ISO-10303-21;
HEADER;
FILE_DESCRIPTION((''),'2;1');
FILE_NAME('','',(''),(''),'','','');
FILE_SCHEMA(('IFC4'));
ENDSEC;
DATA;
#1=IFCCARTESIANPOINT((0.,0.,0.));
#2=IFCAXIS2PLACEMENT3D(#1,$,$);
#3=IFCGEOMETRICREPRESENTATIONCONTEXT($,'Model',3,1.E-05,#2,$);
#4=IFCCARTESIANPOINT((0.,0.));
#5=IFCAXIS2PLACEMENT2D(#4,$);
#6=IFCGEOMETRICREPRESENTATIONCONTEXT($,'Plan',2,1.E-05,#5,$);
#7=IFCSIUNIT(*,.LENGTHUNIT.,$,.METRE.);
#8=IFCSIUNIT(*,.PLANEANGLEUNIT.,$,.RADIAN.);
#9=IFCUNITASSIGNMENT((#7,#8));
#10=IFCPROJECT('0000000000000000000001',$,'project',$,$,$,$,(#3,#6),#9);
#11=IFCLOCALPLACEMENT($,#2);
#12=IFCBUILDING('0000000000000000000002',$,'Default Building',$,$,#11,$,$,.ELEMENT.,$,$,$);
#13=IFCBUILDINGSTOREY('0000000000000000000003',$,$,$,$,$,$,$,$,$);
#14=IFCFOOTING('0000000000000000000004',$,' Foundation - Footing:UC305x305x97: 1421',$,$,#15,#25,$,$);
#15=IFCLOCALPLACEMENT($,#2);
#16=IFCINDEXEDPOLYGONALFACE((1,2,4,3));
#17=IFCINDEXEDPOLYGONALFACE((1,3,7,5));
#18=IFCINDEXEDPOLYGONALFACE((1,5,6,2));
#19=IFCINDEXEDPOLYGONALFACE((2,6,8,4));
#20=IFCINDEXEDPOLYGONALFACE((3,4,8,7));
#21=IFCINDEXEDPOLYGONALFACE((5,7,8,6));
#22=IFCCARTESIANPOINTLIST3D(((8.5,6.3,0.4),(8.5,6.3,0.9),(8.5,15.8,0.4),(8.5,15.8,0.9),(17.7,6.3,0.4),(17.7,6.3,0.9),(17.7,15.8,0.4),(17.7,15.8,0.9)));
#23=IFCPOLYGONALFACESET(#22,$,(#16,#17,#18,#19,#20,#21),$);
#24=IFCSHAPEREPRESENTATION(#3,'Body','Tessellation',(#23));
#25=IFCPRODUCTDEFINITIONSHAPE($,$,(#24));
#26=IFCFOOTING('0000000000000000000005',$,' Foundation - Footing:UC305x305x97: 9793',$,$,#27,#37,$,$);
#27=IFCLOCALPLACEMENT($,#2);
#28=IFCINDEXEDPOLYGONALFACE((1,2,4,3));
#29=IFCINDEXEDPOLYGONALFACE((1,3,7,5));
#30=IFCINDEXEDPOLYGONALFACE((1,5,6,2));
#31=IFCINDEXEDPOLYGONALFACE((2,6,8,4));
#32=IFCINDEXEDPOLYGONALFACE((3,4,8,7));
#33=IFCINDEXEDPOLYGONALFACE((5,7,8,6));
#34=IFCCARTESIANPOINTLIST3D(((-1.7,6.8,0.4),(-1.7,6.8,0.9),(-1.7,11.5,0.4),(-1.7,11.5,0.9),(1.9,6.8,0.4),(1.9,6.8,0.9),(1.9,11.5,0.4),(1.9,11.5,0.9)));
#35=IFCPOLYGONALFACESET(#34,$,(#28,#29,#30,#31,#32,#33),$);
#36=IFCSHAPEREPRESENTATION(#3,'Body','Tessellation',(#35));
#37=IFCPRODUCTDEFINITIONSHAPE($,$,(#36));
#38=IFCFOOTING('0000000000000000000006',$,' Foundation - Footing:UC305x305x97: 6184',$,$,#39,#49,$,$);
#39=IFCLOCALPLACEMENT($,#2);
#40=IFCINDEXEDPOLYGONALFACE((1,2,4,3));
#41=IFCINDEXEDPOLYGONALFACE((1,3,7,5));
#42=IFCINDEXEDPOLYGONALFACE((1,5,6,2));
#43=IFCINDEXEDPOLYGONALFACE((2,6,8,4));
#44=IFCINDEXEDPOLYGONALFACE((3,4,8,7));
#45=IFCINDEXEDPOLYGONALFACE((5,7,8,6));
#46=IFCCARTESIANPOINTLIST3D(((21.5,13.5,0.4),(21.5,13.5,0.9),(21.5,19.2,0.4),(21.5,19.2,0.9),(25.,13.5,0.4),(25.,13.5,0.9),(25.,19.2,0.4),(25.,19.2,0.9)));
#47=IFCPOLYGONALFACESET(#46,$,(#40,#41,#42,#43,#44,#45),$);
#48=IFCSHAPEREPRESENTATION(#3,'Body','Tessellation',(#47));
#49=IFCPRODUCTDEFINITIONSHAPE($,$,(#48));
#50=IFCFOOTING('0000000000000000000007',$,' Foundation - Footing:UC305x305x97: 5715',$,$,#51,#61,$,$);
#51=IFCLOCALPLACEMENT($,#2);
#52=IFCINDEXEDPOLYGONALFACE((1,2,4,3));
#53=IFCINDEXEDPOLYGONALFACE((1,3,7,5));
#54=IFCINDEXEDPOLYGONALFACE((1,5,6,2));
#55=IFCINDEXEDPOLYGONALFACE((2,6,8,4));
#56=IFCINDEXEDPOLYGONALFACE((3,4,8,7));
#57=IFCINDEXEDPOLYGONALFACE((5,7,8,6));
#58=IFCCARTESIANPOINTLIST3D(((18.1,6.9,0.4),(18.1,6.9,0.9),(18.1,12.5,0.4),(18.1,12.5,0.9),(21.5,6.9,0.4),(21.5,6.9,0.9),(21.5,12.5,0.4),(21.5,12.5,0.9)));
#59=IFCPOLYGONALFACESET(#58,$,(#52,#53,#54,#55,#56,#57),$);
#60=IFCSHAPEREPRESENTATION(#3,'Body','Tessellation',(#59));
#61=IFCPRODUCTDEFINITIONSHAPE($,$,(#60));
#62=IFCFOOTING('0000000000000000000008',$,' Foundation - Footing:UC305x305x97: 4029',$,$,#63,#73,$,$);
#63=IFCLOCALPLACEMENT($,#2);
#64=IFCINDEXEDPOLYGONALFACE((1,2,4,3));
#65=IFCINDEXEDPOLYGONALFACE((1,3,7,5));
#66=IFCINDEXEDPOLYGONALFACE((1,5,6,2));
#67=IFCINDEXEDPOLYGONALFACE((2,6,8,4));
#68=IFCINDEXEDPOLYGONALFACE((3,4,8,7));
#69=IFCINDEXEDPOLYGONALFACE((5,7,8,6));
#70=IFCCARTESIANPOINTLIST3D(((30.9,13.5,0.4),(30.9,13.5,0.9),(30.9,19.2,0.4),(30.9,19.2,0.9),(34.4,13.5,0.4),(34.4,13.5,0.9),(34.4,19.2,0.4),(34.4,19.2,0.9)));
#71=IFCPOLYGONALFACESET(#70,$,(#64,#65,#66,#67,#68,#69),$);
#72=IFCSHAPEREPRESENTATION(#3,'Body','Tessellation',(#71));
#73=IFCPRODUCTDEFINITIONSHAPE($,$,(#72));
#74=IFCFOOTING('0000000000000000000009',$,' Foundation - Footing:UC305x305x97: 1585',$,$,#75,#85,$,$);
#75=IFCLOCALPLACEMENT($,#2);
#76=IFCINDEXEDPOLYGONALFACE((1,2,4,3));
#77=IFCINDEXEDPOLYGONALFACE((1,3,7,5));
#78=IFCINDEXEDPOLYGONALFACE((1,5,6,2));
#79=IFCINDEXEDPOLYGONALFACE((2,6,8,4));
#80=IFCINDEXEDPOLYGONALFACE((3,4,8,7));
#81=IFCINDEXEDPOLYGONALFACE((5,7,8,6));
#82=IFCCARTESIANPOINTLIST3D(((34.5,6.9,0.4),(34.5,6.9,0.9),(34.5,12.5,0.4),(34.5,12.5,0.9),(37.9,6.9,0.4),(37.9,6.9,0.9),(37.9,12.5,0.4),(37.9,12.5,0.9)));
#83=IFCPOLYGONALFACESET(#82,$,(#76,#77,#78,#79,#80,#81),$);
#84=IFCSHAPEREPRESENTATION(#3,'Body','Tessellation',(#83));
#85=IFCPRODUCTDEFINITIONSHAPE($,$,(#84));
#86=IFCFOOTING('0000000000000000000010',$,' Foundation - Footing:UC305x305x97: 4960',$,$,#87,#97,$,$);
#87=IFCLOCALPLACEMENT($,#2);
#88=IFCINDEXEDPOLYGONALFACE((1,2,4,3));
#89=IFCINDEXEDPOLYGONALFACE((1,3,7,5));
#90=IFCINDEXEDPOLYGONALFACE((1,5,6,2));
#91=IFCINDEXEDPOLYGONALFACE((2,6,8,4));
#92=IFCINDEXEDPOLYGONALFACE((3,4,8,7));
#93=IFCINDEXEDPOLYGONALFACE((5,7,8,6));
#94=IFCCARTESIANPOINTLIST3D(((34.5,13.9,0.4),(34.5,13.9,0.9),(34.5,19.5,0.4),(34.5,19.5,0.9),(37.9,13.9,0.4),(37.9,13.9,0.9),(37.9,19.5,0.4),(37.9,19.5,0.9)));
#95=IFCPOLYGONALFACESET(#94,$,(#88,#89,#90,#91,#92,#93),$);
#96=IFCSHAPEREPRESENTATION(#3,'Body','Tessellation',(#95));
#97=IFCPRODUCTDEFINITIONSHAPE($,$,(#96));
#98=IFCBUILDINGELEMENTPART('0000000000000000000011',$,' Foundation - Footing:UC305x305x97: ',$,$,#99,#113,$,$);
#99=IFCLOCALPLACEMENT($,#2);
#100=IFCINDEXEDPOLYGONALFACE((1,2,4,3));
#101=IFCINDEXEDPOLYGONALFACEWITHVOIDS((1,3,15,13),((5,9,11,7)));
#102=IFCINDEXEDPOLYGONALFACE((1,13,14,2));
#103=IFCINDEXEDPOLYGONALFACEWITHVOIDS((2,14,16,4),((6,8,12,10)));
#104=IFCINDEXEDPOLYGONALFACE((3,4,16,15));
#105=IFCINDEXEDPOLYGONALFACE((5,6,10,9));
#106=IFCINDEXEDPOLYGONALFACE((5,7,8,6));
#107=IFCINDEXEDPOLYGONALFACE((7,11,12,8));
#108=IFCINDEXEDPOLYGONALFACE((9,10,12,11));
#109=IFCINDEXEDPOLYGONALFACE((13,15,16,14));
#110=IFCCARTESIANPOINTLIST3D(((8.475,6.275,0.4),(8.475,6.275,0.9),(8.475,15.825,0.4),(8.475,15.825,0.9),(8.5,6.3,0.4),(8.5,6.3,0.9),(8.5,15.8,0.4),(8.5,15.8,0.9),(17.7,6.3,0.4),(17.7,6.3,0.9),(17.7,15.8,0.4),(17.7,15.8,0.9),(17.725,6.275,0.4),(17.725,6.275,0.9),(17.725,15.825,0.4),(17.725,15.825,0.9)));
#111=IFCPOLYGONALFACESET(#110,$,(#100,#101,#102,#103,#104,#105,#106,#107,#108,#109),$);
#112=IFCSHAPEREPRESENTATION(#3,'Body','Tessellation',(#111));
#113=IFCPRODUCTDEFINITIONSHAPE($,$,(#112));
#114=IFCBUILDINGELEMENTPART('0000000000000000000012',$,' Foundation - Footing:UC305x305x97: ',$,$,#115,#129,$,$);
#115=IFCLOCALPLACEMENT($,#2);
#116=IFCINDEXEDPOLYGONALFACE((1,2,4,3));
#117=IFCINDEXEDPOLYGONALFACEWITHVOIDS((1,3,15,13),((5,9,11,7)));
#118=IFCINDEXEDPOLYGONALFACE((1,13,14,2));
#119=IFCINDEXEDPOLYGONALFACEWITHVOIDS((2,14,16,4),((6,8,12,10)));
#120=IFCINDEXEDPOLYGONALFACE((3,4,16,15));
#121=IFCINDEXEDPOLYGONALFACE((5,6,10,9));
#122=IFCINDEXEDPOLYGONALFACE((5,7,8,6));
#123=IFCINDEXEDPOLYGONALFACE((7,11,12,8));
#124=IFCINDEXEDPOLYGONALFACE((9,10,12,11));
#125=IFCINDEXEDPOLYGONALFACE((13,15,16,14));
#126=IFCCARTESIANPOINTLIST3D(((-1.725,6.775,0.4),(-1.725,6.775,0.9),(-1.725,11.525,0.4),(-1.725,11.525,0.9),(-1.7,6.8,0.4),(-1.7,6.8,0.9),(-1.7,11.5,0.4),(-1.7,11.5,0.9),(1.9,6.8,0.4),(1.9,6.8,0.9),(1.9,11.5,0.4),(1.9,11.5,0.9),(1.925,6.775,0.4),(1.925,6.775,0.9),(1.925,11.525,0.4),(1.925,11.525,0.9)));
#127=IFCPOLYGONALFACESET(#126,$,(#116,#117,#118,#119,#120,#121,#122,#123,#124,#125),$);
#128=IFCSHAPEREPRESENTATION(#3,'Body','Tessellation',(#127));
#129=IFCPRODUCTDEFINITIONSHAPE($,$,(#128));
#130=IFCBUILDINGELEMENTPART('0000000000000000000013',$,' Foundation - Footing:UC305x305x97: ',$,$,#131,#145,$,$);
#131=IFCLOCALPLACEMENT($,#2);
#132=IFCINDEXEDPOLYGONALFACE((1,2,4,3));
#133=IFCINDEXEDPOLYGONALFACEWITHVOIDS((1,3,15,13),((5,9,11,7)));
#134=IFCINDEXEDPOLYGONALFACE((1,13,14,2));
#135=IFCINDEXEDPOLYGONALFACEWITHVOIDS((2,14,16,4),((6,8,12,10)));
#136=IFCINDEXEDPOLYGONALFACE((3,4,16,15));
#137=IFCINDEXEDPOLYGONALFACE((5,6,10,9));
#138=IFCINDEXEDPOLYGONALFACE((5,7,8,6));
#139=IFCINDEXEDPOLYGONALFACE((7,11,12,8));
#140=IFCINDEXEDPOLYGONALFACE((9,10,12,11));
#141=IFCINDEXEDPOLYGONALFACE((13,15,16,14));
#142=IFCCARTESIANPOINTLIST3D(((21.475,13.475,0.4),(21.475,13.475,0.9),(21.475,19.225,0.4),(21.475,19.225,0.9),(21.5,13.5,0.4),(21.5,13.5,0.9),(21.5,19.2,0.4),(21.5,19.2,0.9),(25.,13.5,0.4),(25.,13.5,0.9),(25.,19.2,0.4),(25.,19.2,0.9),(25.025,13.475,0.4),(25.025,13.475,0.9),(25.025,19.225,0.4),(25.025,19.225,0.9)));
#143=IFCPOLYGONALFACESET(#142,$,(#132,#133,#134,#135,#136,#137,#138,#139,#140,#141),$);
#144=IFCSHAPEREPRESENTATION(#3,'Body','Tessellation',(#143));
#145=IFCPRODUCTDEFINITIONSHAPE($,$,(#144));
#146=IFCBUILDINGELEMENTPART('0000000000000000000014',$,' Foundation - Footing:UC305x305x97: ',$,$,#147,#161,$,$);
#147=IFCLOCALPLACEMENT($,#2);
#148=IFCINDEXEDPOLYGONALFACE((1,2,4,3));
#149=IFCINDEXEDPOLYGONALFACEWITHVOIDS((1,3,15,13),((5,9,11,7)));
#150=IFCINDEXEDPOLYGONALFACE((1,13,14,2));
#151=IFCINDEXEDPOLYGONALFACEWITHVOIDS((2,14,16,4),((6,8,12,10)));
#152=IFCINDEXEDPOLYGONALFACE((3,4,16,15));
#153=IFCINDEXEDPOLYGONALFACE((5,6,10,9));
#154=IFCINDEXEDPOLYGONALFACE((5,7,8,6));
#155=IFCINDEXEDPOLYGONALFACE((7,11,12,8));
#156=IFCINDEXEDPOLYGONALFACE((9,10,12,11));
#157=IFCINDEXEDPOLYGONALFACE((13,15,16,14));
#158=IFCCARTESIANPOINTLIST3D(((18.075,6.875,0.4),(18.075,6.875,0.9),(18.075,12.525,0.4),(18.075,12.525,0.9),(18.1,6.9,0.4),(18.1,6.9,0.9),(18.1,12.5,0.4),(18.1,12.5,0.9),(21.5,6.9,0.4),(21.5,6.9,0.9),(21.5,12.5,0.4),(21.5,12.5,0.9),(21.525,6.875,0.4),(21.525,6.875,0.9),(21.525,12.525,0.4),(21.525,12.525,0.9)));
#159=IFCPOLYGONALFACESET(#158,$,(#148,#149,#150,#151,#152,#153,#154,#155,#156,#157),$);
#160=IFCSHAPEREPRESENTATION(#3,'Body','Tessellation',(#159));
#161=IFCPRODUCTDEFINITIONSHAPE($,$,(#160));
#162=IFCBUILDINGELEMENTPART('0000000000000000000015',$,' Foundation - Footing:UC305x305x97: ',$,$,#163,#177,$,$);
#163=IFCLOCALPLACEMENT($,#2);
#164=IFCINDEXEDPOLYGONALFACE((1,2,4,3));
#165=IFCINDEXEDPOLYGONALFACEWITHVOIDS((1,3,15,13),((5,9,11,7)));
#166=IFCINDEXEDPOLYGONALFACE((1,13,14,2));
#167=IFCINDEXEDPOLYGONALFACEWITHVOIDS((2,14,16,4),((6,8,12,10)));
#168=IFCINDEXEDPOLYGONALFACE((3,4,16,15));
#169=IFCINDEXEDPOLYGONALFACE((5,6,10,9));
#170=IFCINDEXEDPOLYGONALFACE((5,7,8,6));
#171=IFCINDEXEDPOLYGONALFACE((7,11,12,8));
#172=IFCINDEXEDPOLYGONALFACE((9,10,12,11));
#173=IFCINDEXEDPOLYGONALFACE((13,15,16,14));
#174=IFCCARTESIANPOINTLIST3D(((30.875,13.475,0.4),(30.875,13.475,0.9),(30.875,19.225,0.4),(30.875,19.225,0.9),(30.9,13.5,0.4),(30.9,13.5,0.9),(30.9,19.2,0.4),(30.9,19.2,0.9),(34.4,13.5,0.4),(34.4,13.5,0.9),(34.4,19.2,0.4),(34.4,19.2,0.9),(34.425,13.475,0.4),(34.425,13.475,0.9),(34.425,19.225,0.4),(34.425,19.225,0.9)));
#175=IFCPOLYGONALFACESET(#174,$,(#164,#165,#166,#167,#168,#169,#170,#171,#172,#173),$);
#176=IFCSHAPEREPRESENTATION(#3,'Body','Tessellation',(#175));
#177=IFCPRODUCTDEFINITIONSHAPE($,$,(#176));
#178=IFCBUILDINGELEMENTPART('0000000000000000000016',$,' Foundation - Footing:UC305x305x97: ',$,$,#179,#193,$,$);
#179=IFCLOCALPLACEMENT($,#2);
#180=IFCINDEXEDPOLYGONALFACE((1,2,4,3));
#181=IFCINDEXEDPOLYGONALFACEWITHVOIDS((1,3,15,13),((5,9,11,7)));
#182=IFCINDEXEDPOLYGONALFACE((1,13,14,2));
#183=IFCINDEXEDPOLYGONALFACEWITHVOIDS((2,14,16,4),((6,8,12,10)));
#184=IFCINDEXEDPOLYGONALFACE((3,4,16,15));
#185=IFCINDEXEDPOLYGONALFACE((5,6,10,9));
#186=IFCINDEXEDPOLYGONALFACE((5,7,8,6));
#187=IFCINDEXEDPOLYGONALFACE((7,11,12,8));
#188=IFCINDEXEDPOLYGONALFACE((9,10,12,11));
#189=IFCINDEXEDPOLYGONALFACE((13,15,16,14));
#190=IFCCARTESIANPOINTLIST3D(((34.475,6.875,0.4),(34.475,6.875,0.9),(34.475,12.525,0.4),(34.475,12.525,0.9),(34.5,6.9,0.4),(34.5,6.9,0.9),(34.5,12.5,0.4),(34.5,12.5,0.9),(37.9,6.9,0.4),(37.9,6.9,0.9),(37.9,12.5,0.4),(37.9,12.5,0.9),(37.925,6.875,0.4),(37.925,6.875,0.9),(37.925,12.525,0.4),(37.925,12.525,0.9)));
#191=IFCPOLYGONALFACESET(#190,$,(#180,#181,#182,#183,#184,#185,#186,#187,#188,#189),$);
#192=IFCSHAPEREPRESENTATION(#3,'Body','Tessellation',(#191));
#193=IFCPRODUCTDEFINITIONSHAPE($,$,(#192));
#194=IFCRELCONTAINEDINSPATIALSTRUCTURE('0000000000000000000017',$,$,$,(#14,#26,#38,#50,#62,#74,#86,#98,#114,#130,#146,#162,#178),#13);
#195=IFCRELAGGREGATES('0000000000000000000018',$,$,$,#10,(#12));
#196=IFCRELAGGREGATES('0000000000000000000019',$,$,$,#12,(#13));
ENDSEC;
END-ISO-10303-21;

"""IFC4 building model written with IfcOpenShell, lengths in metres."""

from ifc_helpers import new_model, si_unit, origin, origin_2d, place, context, project, spatial, polyline, outline, extrude, element, save


model = new_model("IFC4")

# Units and contexts
model_context = context("Model", 3, precision=1e-05, world=origin())
plan_context = context("Plan", 2, precision=1e-05, world=origin_2d())
ifc_project = project(units=[si_unit("LENGTHUNIT", "METRE"), si_unit("PLANEANGLEUNIT", "RADIAN")], contexts=[model_context, plan_context])

# Building, storey
building_placement = place(None, origin())
building = spatial("IfcBuilding", under=ifc_project, at=building_placement, Name="Default Building", CompositionType="ELEMENT")
storey = spatial("IfcBuildingStorey", under=building)

# Footings
element("IfcFooting", 1, inside=storey, Name=" Foundation - Footing:UC305x305x97: 1421", context=model_context, shape_type="SweptSolid", body=[
    extrude(outline(polyline([(8.5, 15.8, 0.4), (17.7, 15.8, 0.4), (17.7, 6.3, 0.4), (8.5, 6.3, 0.4), (8.5, 15.8, 0.4)])), None, (0.0, 0.0, 1.0), 0.5),
])
element("IfcFooting", 2, inside=storey, Name=" Foundation - Footing:UC305x305x97: 9793", context=model_context, shape_type="SweptSolid", body=[
    extrude(outline(polyline([(1.9, 11.5, 0.4), (-1.7, 11.5, 0.4), (-1.7, 6.8, 0.4), (1.9, 6.8, 0.4), (1.9, 11.5, 0.4)])), None, (0.0, 0.0, 1.0), 0.5),
])
element("IfcFooting", 3, inside=storey, Name=" Foundation - Footing:UC305x305x97: 6184", context=model_context, shape_type="SweptSolid", body=[
    extrude(outline(polyline([(25.0, 19.2, 0.4), (21.5, 19.2, 0.4), (21.5, 13.5, 0.4), (25.0, 13.5, 0.4), (25.0, 19.2, 0.4)])), None, (0.0, 0.0, 1.0), 0.5),
])
element("IfcFooting", 4, inside=storey, Name=" Foundation - Footing:UC305x305x97: 5715", context=model_context, shape_type="SweptSolid", body=[
    extrude(outline(polyline([(21.5, 12.5, 0.4), (18.1, 12.5, 0.4), (18.1, 6.9, 0.4), (21.5, 6.9, 0.4), (21.5, 12.5, 0.4)])), None, (0.0, 0.0, 1.0), 0.5),
])
element("IfcFooting", 5, inside=storey, Name=" Foundation - Footing:UC305x305x97: 4029", context=model_context, shape_type="SweptSolid", body=[
    extrude(outline(polyline([(34.4, 19.2, 0.4), (30.9, 19.2, 0.4), (30.9, 13.5, 0.4), (34.4, 13.5, 0.4), (34.4, 19.2, 0.4)])), None, (0.0, 0.0, 1.0), 0.5),
])
element("IfcFooting", 6, inside=storey, Name=" Foundation - Footing:UC305x305x97: 1585", context=model_context, shape_type="SweptSolid", body=[
    extrude(outline(polyline([(37.9, 12.5, 0.4), (34.5, 12.5, 0.4), (34.5, 6.9, 0.4), (37.9, 6.9, 0.4), (37.9, 12.5, 0.4)])), None, (0.0, 0.0, 1.0), 0.5),
])
element("IfcFooting", 7, inside=storey, Name=" Foundation - Footing:UC305x305x97: 4960", context=model_context, shape_type="SweptSolid", body=[
    extrude(outline(polyline([(37.9, 19.5, 0.4), (34.5, 19.5, 0.4), (34.5, 13.9, 0.4), (37.9, 13.9, 0.4), (37.9, 19.5, 0.4)])), None, (0.0, 0.0, 1.0), 0.5),
])

# Building element parts, openings
building_element_part_1 = element("IfcBuildingElementPart", 8, inside=storey, Name=" Foundation - Footing:UC305x305x97: ", context=model_context, shape_type="SweptSolid", body=[
    extrude(outline(polyline([(8.475, 15.825, 0.4), (17.725, 15.825, 0.4), (17.725, 6.275, 0.4), (8.475, 6.275, 0.4), (8.475, 15.825, 0.4)])), None, (0.0, 0.0, 1.0), 0.5),
])
element("IfcOpeningElement", 9, inside=storey, cuts=building_element_part_1, context=model_context, shape_type="SweptSolid", body=[
    extrude(outline(polyline([(8.5, 15.8, 0.4), (17.7, 15.8, 0.4), (17.7, 6.3, 0.4), (8.5, 6.3, 0.4), (8.5, 15.8, 0.4)])), None, (0.0, 0.0, 1.0), 0.5),
])
building_element_part_2 = element("IfcBuildingElementPart", 10, inside=storey, Name=" Foundation - Footing:UC305x305x97: ", context=model_context, shape_type="SweptSolid", body=[
    extrude(outline(polyline([(1.925, 11.525, 0.4), (-1.725, 11.525, 0.4), (-1.725, 6.775, 0.4), (1.925, 6.775, 0.4), (1.925, 11.525, 0.4)])), None, (0.0, 0.0, 1.0), 0.5),
])
element("IfcOpeningElement", 11, inside=storey, cuts=building_element_part_2, context=model_context, shape_type="SweptSolid", body=[
    extrude(outline(polyline([(1.9, 11.5, 0.4), (-1.7, 11.5, 0.4), (-1.7, 6.8, 0.4), (1.9, 6.8, 0.4), (1.9, 11.5, 0.4)])), None, (0.0, 0.0, 1.0), 0.5),
])
building_element_part_3 = element("IfcBuildingElementPart", 12, inside=storey, Name=" Foundation - Footing:UC305x305x97: ", context=model_context, shape_type="SweptSolid", body=[
    extrude(outline(polyline([(25.025, 19.225, 0.4), (21.475, 19.225, 0.4), (21.475, 13.475, 0.4), (25.025, 13.475, 0.4), (25.025, 19.225, 0.4)])), None, (0.0, 0.0, 1.0), 0.5),
])
element("IfcOpeningElement", 13, inside=storey, cuts=building_element_part_3, context=model_context, shape_type="SweptSolid", body=[
    extrude(outline(polyline([(25.0, 19.2, 0.4), (21.5, 19.2, 0.4), (21.5, 13.5, 0.4), (25.0, 13.5, 0.4), (25.0, 19.2, 0.4)])), None, (0.0, 0.0, 1.0), 0.5),
])
building_element_part_4 = element("IfcBuildingElementPart", 14, inside=storey, Name=" Foundation - Footing:UC305x305x97: ", context=model_context, shape_type="SweptSolid", body=[
    extrude(outline(polyline([(21.525, 12.525, 0.4), (18.075, 12.525, 0.4), (18.075, 6.875, 0.4), (21.525, 6.875, 0.4), (21.525, 12.525, 0.4)])), None, (0.0, 0.0, 1.0), 0.5),
])
element("IfcOpeningElement", 15, inside=storey, cuts=building_element_part_4, context=model_context, shape_type="SweptSolid", body=[
    extrude(outline(polyline([(21.5, 12.5, 0.4), (18.1, 12.5, 0.4), (18.1, 6.9, 0.4), (21.5, 6.9, 0.4), (21.5, 12.5, 0.4)])), None, (0.0, 0.0, 1.0), 0.5),
])
building_element_part_5 = element("IfcBuildingElementPart", 16, inside=storey, Name=" Foundation - Footing:UC305x305x97: ", context=model_context, shape_type="SweptSolid", body=[
    extrude(outline(polyline([(34.425, 19.225, 0.4), (30.875, 19.225, 0.4), (30.875, 13.475, 0.4), (34.425, 13.475, 0.4), (34.425, 19.225, 0.4)])), None, (0.0, 0.0, 1.0), 0.5),
])
element("IfcOpeningElement", 17, inside=storey, cuts=building_element_part_5, context=model_context, shape_type="SweptSolid", body=[
    extrude(outline(polyline([(34.4, 19.2, 0.4), (30.9, 19.2, 0.4), (30.9, 13.5, 0.4), (34.4, 13.5, 0.4), (34.4, 19.2, 0.4)])), None, (0.0, 0.0, 1.0), 0.5),
])
building_element_part_6 = element("IfcBuildingElementPart", 18, inside=storey, Name=" Foundation - Footing:UC305x305x97: ", context=model_context, shape_type="SweptSolid", body=[
    extrude(outline(polyline([(37.925, 12.525, 0.4), (34.475, 12.525, 0.4), (34.475, 6.875, 0.4), (37.925, 6.875, 0.4), (37.925, 12.525, 0.4)])), None, (0.0, 0.0, 1.0), 0.5),
])
element("IfcOpeningElement", 19, inside=storey, cuts=building_element_part_6, context=model_context, shape_type="SweptSolid", body=[
    extrude(outline(polyline([(37.9, 12.5, 0.4), (34.5, 12.5, 0.4), (34.5, 6.9, 0.4), (37.9, 6.9, 0.4), (37.9, 12.5, 0.4)])), None, (0.0, 0.0, 1.0), 0.5),
])

save(model, "model.ifc")
